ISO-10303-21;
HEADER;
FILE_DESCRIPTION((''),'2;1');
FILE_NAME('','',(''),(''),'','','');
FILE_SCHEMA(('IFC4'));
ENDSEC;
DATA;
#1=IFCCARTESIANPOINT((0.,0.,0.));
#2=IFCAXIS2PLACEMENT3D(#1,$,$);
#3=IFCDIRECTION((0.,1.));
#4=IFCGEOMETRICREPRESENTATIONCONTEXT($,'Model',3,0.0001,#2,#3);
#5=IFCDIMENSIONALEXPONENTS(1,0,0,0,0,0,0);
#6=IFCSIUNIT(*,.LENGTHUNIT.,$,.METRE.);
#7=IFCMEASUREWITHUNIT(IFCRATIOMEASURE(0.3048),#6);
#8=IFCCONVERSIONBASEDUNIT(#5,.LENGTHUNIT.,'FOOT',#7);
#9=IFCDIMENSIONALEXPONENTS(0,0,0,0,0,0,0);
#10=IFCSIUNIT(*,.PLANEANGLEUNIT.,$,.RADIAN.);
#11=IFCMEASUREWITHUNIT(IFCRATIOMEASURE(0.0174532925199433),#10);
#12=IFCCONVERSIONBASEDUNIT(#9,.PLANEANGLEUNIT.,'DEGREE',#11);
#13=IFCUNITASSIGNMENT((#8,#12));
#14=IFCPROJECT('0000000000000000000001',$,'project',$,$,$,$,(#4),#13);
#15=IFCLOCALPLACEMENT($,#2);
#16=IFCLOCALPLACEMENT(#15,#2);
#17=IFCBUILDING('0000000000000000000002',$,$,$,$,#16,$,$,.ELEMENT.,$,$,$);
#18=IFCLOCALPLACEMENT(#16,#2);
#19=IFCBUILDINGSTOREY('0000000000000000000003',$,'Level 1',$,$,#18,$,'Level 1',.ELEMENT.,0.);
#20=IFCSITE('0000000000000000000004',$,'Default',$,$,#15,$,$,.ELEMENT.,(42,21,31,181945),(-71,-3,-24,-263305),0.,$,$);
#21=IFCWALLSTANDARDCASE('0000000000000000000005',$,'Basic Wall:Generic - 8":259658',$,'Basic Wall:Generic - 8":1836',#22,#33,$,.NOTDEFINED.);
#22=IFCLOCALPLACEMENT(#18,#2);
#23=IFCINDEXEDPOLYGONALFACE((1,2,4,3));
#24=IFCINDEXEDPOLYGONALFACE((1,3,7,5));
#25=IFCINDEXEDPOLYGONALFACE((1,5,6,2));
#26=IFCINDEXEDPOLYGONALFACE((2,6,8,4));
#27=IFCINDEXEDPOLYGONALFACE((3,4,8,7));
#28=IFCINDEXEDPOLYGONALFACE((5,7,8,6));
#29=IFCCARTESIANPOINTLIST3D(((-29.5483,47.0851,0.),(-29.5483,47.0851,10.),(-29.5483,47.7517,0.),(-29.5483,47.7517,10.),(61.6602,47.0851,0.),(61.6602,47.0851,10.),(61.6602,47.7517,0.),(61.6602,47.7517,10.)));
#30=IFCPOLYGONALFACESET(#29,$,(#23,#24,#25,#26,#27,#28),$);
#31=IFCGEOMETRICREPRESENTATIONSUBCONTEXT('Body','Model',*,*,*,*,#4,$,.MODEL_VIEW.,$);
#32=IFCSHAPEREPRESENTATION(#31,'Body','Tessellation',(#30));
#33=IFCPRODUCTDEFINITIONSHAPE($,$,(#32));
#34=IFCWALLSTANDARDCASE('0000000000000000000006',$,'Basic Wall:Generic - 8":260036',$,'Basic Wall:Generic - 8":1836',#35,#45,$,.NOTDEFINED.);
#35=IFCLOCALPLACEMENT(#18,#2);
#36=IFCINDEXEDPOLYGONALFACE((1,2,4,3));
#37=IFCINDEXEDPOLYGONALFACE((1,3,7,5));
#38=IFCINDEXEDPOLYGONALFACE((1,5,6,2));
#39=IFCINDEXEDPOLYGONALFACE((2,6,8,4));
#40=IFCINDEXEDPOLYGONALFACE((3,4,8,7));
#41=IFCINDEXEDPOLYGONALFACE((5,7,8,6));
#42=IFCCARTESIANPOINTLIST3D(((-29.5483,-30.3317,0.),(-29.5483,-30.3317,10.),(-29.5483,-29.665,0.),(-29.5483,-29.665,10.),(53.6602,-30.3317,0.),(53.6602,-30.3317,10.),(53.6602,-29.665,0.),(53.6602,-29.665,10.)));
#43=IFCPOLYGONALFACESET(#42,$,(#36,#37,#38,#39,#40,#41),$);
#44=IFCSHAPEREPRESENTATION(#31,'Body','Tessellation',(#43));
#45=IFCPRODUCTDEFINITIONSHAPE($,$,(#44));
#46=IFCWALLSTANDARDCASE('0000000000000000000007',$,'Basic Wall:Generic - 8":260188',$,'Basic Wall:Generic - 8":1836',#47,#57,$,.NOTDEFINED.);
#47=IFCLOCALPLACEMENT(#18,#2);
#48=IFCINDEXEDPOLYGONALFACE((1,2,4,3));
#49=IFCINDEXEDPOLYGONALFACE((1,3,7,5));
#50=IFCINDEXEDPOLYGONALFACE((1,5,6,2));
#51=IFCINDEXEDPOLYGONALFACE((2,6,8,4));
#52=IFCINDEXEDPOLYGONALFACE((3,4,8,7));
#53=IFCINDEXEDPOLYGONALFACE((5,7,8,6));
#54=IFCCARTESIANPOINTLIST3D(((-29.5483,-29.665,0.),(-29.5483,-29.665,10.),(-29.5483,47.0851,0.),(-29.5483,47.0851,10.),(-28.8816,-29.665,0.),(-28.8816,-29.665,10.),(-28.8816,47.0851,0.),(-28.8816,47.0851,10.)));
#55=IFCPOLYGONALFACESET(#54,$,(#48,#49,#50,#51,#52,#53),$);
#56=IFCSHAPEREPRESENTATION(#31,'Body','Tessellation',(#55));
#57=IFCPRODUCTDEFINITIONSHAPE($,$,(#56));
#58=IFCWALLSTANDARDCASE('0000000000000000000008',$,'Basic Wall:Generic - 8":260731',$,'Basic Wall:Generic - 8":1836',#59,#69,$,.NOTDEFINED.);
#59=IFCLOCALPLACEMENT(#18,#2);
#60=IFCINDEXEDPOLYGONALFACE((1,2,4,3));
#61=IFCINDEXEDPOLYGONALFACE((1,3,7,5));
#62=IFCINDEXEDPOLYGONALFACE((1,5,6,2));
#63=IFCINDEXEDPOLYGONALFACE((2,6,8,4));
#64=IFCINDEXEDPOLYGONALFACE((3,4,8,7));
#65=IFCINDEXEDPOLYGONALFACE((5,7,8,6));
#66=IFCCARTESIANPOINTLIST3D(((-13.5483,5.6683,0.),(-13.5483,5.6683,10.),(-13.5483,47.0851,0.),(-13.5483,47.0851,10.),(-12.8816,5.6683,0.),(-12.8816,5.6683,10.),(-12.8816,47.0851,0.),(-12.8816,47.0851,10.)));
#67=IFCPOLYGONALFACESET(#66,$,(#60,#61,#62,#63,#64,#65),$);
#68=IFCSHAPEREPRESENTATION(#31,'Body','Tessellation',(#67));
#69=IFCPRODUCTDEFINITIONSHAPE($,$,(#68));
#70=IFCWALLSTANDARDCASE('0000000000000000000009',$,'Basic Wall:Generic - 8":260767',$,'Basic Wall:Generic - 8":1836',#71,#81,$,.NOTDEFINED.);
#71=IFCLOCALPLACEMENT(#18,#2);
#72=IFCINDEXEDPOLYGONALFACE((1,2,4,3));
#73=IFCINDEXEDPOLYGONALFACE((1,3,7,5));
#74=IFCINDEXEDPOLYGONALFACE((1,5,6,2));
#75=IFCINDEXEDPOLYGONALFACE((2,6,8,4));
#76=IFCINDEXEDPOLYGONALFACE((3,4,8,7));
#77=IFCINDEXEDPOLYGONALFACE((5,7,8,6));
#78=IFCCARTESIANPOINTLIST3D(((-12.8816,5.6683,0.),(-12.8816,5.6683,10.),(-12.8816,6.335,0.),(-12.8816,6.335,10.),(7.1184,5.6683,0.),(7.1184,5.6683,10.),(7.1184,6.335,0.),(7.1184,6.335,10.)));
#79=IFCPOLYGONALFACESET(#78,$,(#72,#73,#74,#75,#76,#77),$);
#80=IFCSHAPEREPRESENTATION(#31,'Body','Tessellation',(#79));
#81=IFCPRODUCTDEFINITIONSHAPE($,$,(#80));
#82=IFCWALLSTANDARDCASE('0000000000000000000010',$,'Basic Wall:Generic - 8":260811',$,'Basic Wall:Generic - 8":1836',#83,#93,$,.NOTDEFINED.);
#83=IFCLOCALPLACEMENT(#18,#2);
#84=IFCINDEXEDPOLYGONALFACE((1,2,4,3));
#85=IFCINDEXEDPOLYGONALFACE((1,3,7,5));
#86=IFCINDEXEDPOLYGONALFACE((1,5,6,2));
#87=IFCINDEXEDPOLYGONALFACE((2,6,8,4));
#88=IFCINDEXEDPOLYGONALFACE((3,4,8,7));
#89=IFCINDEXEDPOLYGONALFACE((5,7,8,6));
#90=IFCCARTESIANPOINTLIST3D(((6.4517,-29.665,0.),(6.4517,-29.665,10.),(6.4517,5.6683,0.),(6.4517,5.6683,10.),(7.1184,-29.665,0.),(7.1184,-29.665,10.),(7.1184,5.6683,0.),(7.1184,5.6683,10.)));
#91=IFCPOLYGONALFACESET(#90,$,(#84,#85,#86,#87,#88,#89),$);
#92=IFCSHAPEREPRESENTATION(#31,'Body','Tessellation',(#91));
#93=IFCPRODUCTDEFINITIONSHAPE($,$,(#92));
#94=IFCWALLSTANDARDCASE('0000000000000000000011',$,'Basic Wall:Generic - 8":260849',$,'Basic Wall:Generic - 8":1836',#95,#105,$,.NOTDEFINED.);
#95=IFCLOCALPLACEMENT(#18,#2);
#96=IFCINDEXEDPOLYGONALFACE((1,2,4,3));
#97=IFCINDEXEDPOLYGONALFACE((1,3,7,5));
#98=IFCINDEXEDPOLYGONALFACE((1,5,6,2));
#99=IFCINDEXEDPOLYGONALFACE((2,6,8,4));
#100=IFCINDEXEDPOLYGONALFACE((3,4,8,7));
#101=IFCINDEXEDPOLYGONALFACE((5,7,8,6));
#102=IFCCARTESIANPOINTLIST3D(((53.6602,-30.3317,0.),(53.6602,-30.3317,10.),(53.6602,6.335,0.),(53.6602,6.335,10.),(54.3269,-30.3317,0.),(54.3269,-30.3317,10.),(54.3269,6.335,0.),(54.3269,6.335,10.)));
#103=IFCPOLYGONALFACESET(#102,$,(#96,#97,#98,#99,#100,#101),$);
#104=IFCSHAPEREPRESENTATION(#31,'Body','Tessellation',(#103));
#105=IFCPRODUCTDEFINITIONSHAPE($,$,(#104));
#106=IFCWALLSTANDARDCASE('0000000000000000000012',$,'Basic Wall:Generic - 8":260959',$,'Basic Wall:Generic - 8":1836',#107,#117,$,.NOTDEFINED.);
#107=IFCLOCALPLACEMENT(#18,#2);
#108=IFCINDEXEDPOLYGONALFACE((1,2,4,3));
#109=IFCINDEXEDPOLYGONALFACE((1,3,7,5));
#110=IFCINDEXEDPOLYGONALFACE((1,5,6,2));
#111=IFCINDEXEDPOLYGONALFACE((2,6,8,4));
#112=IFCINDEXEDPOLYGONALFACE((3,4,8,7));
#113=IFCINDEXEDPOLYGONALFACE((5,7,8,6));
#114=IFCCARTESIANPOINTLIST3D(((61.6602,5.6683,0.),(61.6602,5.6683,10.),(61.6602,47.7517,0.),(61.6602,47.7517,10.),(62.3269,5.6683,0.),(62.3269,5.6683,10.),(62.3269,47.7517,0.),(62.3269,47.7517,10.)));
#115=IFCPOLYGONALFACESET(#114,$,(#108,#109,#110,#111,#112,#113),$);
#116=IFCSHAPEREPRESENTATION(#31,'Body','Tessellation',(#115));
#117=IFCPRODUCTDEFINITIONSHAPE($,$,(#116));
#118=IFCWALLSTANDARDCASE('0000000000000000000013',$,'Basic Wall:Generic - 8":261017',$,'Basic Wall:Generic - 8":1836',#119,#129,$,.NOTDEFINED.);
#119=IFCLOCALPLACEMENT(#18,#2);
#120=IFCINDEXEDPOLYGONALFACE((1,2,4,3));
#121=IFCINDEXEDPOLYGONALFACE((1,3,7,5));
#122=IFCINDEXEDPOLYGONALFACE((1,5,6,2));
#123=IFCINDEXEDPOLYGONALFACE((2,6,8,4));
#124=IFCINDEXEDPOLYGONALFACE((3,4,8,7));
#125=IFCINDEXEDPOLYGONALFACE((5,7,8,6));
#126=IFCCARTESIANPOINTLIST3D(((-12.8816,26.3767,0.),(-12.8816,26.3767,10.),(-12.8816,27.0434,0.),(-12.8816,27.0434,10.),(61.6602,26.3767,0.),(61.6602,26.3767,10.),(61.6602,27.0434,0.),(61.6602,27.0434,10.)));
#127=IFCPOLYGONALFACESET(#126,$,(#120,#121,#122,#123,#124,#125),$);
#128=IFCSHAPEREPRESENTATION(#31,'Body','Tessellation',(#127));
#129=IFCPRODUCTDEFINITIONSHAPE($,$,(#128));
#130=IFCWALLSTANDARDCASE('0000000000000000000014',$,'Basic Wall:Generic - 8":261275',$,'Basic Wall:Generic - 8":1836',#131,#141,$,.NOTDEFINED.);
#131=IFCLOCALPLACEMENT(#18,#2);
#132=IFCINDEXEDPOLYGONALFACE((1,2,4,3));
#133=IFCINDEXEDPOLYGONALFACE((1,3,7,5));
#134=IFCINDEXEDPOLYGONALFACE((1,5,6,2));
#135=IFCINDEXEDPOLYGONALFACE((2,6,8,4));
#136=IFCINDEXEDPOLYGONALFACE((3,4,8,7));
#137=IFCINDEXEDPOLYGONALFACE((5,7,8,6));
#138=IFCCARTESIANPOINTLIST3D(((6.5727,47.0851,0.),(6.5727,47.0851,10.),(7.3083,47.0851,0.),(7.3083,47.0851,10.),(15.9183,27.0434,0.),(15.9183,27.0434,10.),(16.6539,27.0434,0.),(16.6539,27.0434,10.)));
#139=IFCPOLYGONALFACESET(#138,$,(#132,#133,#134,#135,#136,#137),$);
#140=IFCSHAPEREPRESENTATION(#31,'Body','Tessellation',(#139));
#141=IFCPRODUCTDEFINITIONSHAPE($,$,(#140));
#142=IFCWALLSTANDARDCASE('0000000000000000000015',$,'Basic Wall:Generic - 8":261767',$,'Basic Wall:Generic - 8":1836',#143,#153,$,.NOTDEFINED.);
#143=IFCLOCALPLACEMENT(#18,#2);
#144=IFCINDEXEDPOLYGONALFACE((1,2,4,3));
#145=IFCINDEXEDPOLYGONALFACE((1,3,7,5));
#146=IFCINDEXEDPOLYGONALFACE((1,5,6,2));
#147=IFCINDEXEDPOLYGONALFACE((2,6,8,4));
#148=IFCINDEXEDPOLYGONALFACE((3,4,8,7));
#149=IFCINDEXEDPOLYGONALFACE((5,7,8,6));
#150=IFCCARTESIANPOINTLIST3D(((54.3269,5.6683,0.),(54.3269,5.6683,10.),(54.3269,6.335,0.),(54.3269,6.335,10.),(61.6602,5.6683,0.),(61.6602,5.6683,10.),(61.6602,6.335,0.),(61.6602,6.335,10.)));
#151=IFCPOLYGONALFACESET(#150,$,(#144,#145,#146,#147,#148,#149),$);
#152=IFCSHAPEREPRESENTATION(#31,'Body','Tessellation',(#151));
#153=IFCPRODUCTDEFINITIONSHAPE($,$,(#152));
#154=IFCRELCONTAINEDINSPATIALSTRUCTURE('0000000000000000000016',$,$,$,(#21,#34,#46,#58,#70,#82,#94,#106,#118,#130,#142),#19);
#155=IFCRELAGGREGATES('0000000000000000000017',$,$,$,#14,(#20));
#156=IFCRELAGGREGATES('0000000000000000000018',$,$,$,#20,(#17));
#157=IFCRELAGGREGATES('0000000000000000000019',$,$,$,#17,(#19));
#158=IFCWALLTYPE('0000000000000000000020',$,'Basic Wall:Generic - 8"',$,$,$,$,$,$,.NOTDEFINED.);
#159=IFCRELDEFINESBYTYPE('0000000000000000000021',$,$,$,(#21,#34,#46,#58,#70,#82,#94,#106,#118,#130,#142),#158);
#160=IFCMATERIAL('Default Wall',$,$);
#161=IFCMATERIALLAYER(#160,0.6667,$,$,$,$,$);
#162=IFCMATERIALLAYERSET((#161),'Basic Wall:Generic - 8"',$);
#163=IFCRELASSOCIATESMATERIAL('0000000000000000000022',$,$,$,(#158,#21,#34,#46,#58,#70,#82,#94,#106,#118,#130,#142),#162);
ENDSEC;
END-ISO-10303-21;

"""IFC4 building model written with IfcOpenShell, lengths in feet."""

from ifc_helpers import new_model, entity, si_unit, converted_unit, direction, frame, frame_2d, origin, place, context, subcontext, project, spatial, polyline, rectangle, outline, extrude, material, layer, layer_set, layer_usage, type_object, element, save


model = new_model("IFC4")

# Units and contexts
model_context = context("Model", 3, precision=0.0001, world=origin(), true_north=direction((0.0, 1.0)))
body_context = subcontext(model_context, "Body", "Model", "MODEL_VIEW")
ifc_project = project(units=[converted_unit("LENGTHUNIT", "FOOT", entity("IfcRatioMeasure", 0.3048), si_unit("LENGTHUNIT", "METRE"), dimensions=[1, 0, 0, 0, 0, 0, 0]), converted_unit("PLANEANGLEUNIT", "DEGREE", entity("IfcRatioMeasure", 0.0174532925199433), si_unit("PLANEANGLEUNIT", "RADIAN"), dimensions=[0, 0, 0, 0, 0, 0, 0])], contexts=[model_context])

# Site, building, storey
site_placement = place(None, origin())
site = spatial("IfcSite", under=ifc_project, at=site_placement, Name="Default", CompositionType="ELEMENT", RefLatitude=(42, 21, 31, 181945), RefLongitude=(-71, -3, -24, -263305), RefElevation=0.0)
building_placement = place(site_placement, origin())
building = spatial("IfcBuilding", under=site, at=building_placement, CompositionType="ELEMENT")
storey_placement = place(building_placement, origin())
storey = spatial("IfcBuildingStorey", under=building, at=storey_placement, Name="Level 1", LongName="Level 1", CompositionType="ELEMENT", Elevation=0.0)

# Walls
ifc_material = material(Name="Default Wall")
ifc_layer = layer(ifc_material, 0.6667)
ifc_layer_set = layer_set([ifc_layer], Name="Basic Wall:Generic - 8\"")
ifc_layer_usage_1 = layer_usage(ifc_layer_set, "AXIS2", "NEGATIVE", 0.3333)
wall_type = type_object("IfcWallType", Name="Basic Wall:Generic - 8\"", PredefinedType="NOTDEFINED", material=ifc_layer_set)
wall_1_placement = place(storey_placement, frame((-29.5483, 47.4184, 0.0)))
element("IfcWallStandardCase", 1, at=wall_1_placement, inside=storey, type_object=wall_type, material=ifc_layer_usage_1, Name="Basic Wall:Generic - 8\":259658", ObjectType="Basic Wall:Generic - 8\":1836", PredefinedType="NOTDEFINED", context=body_context, shape_type="SweptSolid", body=[
    extrude(rectangle(XDim=91.2085, YDim=0.6667, at=frame_2d((45.6043, 0.0), x_axis=(-1.0, 0.0))), origin(), (0.0, 0.0, 1.0), 10.0),
])
ifc_layer_usage_2 = layer_usage(ifc_layer_set, "AXIS2", "NEGATIVE", 0.3333)
wall_2_placement = place(storey_placement, frame((53.6602, -29.9983, 0.0), z_axis=(0.0, 0.0, 1.0), x_axis=(-1.0, 0.0, 0.0)))
element("IfcWallStandardCase", 2, at=wall_2_placement, inside=storey, type_object=wall_type, material=ifc_layer_usage_2, Name="Basic Wall:Generic - 8\":260036", ObjectType="Basic Wall:Generic - 8\":1836", PredefinedType="NOTDEFINED", context=body_context, shape_type="SweptSolid", body=[
    extrude(rectangle(XDim=83.2085, YDim=0.6667, at=frame_2d((41.6043, 0.0), x_axis=(-1.0, 0.0))), origin(), (0.0, 0.0, 1.0), 10.0),
])
ifc_layer_usage_3 = layer_usage(ifc_layer_set, "AXIS2", "NEGATIVE", 0.3333)
wall_3_placement = place(storey_placement, frame((-29.215, 47.0851, 0.0), z_axis=(0.0, 0.0, 1.0), x_axis=(0.0, -1.0, 0.0)))
element("IfcWallStandardCase", 3, at=wall_3_placement, inside=storey, type_object=wall_type, material=ifc_layer_usage_3, Name="Basic Wall:Generic - 8\":260188", ObjectType="Basic Wall:Generic - 8\":1836", PredefinedType="NOTDEFINED", context=body_context, shape_type="SweptSolid", body=[
    extrude(rectangle(XDim=76.7501, YDim=0.6667, at=frame_2d((38.375, 0.0), x_axis=(-1.0, 0.0))), origin(), (0.0, 0.0, 1.0), 10.0),
])
ifc_layer_usage_4 = layer_usage(ifc_layer_set, "AXIS2", "NEGATIVE", 0.3333)
wall_4_placement = place(storey_placement, frame((-13.215, 47.0851, 0.0), z_axis=(0.0, 0.0, 1.0), x_axis=(0.0, -1.0, 0.0)))
element("IfcWallStandardCase", 4, at=wall_4_placement, inside=storey, type_object=wall_type, material=ifc_layer_usage_4, Name="Basic Wall:Generic - 8\":260731", ObjectType="Basic Wall:Generic - 8\":1836", PredefinedType="NOTDEFINED", context=body_context, shape_type="SweptSolid", body=[
    extrude(rectangle(XDim=41.4167, YDim=0.6667, at=frame_2d((20.7084, 0.0), x_axis=(-1.0, 0.0))), origin(), (0.0, 0.0, 1.0), 10.0),
])
ifc_layer_usage_5 = layer_usage(ifc_layer_set, "AXIS2", "NEGATIVE", 0.3333)
wall_5_placement = place(storey_placement, frame((-12.8816, 6.0017, 0.0)))
element("IfcWallStandardCase", 5, at=wall_5_placement, inside=storey, type_object=wall_type, material=ifc_layer_usage_5, Name="Basic Wall:Generic - 8\":260767", ObjectType="Basic Wall:Generic - 8\":1836", PredefinedType="NOTDEFINED", context=body_context, shape_type="SweptSolid", body=[
    extrude(rectangle(XDim=20.0, YDim=0.6667, at=frame_2d((10.0, 0.0), x_axis=(-1.0, 0.0))), origin(), (0.0, 0.0, 1.0), 10.0),
])
ifc_layer_usage_6 = layer_usage(ifc_layer_set, "AXIS2", "NEGATIVE", 0.3333)
wall_6_placement = place(storey_placement, frame((6.785, 5.6683, 0.0), z_axis=(0.0, 0.0, 1.0), x_axis=(0.0, -1.0, 0.0)))
element("IfcWallStandardCase", 6, at=wall_6_placement, inside=storey, type_object=wall_type, material=ifc_layer_usage_6, Name="Basic Wall:Generic - 8\":260811", ObjectType="Basic Wall:Generic - 8\":1836", PredefinedType="NOTDEFINED", context=body_context, shape_type="SweptSolid", body=[
    extrude(rectangle(XDim=35.3333, YDim=0.6667, at=frame_2d((17.6667, 0.0), x_axis=(-1.0, 0.0))), origin(), (0.0, 0.0, 1.0), 10.0),
])
ifc_layer_usage_7 = layer_usage(ifc_layer_set, "AXIS2", "NEGATIVE", 0.3333)
wall_7_placement = place(storey_placement, frame((53.9936, 6.335, 0.0), z_axis=(0.0, 0.0, 1.0), x_axis=(0.0, -1.0, 0.0)))
element("IfcWallStandardCase", 7, at=wall_7_placement, inside=storey, type_object=wall_type, material=ifc_layer_usage_7, Name="Basic Wall:Generic - 8\":260849", ObjectType="Basic Wall:Generic - 8\":1836", PredefinedType="NOTDEFINED", context=body_context, shape_type="SweptSolid", body=[
    extrude(rectangle(XDim=36.6667, YDim=0.6667, at=frame_2d((18.3333, 0.0), x_axis=(-1.0, 0.0))), origin(), (0.0, 0.0, 1.0), 10.0),
])
ifc_layer_usage_8 = layer_usage(ifc_layer_set, "AXIS2", "NEGATIVE", 0.3333)
wall_8_placement = place(storey_placement, frame((61.9936, 47.7517, 0.0), z_axis=(0.0, 0.0, 1.0), x_axis=(0.0, -1.0, 0.0)))
element("IfcWallStandardCase", 8, at=wall_8_placement, inside=storey, type_object=wall_type, material=ifc_layer_usage_8, Name="Basic Wall:Generic - 8\":260959", ObjectType="Basic Wall:Generic - 8\":1836", PredefinedType="NOTDEFINED", context=body_context, shape_type="SweptSolid", body=[
    extrude(rectangle(XDim=42.0834, YDim=0.6667, at=frame_2d((21.0417, 0.0), x_axis=(-1.0, 0.0))), origin(), (0.0, 0.0, 1.0), 10.0),
])
ifc_layer_usage_9 = layer_usage(ifc_layer_set, "AXIS2", "NEGATIVE", 0.3333)
wall_9_placement = place(storey_placement, frame((-12.8816, 26.71, 0.0)))
element("IfcWallStandardCase", 9, at=wall_9_placement, inside=storey, type_object=wall_type, material=ifc_layer_usage_9, Name="Basic Wall:Generic - 8\":261017", ObjectType="Basic Wall:Generic - 8\":1836", PredefinedType="NOTDEFINED", context=body_context, shape_type="SweptSolid", body=[
    extrude(rectangle(XDim=74.5419, YDim=0.6667, at=frame_2d((37.2709, 0.0), x_axis=(-1.0, 0.0))), origin(), (0.0, 0.0, 1.0), 10.0),
])
ifc_layer_usage_10 = layer_usage(ifc_layer_set, "AXIS2", "NEGATIVE", 0.3333)
wall_10_placement = place(storey_placement, frame((6.8748, 47.226, 0.0), z_axis=(0.0, 0.0, 1.0), x_axis=(0.422618, -0.906308, 0.0)))
element("IfcWallStandardCase", 10, at=wall_10_placement, inside=storey, type_object=wall_type, material=ifc_layer_usage_10, Name="Basic Wall:Generic - 8\":261275", ObjectType="Basic Wall:Generic - 8\":1836", PredefinedType="NOTDEFINED", context=body_context, shape_type="SweptSolid", body=[
    extrude(outline(polyline([(22.1136, -0.3333), (22.4244, 0.3333), (0.3109, 0.3333), (0.0, -0.3333), (22.1136, -0.3333)])), origin(), (0.0, 0.0, 1.0), 10.0),
])
ifc_layer_usage_11 = layer_usage(ifc_layer_set, "AXIS2", "NEGATIVE", 0.3333)
wall_11_placement = place(storey_placement, frame((54.3269, 6.0017, 0.0)))
element("IfcWallStandardCase", 11, at=wall_11_placement, inside=storey, type_object=wall_type, material=ifc_layer_usage_11, Name="Basic Wall:Generic - 8\":261767", ObjectType="Basic Wall:Generic - 8\":1836", PredefinedType="NOTDEFINED", context=body_context, shape_type="SweptSolid", body=[
    extrude(rectangle(XDim=7.3333, YDim=0.6667, at=frame_2d((3.6667, 0.0), x_axis=(-1.0, 0.0))), origin(), (0.0, 0.0, 1.0), 10.0),
])

save(model, "model.ifc")
